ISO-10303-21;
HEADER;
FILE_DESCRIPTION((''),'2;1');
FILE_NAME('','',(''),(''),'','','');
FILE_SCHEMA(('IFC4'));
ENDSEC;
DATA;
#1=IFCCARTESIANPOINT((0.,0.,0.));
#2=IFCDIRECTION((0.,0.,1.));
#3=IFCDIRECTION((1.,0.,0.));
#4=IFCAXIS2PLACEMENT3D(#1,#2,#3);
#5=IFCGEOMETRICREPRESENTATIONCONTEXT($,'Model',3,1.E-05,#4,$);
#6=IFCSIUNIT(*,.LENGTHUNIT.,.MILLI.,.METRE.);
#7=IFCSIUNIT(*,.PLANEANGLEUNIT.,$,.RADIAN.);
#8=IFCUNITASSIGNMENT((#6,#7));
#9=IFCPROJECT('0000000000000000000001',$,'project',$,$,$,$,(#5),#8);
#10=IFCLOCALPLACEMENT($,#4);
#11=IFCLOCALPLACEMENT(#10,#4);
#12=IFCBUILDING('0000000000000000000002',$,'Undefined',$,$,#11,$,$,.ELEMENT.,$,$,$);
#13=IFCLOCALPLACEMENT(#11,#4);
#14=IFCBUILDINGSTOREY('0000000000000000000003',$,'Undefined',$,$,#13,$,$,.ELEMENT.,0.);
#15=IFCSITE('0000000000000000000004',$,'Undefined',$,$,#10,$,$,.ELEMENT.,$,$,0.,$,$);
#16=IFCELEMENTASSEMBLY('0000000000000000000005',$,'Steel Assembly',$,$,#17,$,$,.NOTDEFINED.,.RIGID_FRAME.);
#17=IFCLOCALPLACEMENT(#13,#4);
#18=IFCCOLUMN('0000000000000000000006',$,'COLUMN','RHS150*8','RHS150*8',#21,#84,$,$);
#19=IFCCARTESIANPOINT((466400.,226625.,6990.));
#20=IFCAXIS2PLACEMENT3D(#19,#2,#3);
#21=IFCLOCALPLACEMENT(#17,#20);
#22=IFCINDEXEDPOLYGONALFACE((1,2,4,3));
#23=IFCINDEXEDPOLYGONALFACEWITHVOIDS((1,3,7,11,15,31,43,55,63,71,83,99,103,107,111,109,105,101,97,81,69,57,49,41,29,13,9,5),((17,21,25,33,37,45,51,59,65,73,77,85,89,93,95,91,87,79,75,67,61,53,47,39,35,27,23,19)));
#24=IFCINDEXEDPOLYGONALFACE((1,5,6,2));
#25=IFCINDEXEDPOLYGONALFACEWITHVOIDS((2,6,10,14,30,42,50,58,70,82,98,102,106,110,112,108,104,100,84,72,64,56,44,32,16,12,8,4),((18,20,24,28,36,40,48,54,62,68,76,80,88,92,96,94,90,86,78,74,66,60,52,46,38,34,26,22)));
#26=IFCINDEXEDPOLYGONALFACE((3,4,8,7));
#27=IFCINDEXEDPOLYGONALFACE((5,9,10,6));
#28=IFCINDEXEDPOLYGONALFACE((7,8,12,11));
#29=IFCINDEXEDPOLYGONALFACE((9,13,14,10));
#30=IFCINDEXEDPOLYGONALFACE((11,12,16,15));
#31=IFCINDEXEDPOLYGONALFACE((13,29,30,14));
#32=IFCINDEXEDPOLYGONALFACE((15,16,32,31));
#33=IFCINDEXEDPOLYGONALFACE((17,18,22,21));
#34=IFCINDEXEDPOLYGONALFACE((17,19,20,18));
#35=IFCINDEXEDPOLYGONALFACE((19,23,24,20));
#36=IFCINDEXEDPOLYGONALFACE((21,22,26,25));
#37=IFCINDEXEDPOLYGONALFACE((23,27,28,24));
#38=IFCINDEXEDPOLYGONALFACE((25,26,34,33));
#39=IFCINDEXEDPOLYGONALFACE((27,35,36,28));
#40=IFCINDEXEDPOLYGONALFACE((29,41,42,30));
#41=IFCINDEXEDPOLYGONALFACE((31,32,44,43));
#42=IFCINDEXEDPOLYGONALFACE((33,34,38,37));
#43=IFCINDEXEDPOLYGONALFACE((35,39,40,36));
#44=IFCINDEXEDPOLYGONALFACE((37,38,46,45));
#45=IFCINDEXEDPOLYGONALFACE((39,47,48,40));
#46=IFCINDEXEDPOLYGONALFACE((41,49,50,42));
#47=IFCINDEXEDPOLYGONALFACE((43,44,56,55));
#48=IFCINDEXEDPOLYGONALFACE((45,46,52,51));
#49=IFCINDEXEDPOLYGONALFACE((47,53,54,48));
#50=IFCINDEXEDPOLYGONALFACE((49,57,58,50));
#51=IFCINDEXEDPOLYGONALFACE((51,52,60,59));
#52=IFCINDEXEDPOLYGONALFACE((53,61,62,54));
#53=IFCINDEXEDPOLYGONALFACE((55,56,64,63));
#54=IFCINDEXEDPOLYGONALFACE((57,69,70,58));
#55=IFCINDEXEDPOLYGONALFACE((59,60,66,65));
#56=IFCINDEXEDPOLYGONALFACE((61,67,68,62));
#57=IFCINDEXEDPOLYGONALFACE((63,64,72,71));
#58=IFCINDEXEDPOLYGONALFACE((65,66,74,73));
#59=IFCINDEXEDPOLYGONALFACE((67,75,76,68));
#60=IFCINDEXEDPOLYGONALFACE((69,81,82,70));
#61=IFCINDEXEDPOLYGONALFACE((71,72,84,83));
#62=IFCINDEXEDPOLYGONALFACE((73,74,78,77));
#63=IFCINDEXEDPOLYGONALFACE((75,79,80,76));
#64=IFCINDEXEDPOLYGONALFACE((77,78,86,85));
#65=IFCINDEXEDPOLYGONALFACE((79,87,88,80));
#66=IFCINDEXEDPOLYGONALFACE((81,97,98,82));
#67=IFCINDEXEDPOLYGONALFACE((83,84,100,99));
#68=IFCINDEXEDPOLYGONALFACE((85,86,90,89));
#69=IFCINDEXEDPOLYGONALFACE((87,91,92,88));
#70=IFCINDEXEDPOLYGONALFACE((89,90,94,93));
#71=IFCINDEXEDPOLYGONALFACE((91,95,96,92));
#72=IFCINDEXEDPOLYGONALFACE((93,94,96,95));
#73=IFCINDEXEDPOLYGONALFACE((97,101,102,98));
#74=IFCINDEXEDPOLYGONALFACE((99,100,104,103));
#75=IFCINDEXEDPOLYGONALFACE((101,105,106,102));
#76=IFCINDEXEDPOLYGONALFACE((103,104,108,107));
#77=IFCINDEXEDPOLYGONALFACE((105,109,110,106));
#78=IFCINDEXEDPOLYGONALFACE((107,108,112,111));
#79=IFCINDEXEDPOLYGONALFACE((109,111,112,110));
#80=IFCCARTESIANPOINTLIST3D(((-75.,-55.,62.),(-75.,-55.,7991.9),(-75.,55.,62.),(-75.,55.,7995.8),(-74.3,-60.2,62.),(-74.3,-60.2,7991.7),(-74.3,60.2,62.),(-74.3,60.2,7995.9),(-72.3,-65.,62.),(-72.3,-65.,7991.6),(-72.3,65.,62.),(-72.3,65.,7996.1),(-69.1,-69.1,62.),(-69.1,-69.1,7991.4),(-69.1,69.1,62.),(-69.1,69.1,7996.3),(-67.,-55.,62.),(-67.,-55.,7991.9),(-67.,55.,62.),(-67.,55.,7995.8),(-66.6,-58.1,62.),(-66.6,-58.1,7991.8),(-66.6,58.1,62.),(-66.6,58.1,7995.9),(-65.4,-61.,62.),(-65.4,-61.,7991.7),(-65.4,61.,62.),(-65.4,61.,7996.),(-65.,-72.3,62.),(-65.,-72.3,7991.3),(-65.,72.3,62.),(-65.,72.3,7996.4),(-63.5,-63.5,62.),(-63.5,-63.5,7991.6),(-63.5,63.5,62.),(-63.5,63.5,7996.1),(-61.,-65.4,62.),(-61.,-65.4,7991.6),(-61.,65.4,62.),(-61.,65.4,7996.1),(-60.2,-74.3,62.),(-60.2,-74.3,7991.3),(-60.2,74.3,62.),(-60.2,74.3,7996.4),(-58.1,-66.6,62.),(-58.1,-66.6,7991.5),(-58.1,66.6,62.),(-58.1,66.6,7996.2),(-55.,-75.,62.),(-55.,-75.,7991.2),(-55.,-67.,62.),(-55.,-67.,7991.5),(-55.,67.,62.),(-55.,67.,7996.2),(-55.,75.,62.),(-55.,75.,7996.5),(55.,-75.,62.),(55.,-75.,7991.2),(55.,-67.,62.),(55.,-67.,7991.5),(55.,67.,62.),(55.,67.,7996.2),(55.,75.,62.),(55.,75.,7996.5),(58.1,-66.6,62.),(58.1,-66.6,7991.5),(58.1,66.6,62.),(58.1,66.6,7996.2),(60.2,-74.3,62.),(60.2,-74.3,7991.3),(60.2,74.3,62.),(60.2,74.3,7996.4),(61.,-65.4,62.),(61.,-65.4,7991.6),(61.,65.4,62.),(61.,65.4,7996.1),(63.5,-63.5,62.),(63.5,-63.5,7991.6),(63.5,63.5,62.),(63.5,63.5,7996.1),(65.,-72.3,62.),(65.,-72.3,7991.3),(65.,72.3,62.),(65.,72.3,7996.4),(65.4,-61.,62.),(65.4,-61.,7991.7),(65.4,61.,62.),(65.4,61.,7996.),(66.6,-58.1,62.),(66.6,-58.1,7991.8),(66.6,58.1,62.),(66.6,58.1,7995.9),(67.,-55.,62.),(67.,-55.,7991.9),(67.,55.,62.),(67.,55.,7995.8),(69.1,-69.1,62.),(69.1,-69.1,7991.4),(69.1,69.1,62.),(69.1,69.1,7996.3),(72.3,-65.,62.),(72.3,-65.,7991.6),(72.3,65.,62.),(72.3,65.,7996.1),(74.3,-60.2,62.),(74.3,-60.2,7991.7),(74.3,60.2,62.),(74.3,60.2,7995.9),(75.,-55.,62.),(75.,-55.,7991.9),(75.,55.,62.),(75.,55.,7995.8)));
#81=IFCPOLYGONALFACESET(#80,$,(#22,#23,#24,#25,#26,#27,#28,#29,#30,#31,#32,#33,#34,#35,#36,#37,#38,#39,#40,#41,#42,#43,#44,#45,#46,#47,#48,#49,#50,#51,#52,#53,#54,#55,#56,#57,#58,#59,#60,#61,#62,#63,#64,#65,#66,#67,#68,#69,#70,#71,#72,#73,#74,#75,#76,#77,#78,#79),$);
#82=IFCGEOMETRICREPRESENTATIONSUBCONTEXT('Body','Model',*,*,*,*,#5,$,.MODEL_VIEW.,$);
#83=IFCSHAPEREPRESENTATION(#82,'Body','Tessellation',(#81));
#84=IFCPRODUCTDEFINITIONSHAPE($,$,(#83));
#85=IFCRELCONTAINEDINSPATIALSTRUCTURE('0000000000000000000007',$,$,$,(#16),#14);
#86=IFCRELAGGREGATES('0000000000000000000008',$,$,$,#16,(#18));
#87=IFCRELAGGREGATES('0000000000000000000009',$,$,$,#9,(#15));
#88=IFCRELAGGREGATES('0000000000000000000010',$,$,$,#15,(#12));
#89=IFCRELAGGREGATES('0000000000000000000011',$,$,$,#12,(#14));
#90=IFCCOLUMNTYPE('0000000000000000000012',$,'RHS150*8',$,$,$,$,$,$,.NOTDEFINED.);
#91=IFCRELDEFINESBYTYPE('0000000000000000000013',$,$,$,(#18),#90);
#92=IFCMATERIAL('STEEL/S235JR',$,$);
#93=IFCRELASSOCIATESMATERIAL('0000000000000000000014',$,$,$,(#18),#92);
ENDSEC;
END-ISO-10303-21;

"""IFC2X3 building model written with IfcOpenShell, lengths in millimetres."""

from ifc_helpers import new_model, si_unit, frame, origin_with_axes, origin_2d_with_axis, place, context, subcontext, project, spatial, hollow_rectangle, extrude, clip, halfspace, material, type_object, element, aggregate, save


model = new_model("IFC2X3")

# Units and contexts
model_context = context("Model", 3, precision=1e-05, world=origin_with_axes())
body_context = subcontext(model_context, "Body", "Model", "MODEL_VIEW")
ifc_project = project(units=[si_unit("LENGTHUNIT", "METRE", prefix="MILLI"), si_unit("PLANEANGLEUNIT", "RADIAN")], contexts=[model_context])

# Site, building, storey
site_placement = place(None, origin_with_axes())
site = spatial("IfcSite", under=ifc_project, at=site_placement, Name="Undefined", CompositionType="ELEMENT", RefElevation=0.0)
building_placement = place(site_placement, origin_with_axes())
building = spatial("IfcBuilding", under=site, at=building_placement, Name="Undefined", CompositionType="ELEMENT")
storey_placement = place(building_placement, origin_with_axes())
storey = spatial("IfcBuildingStorey", under=building, at=storey_placement, Name="Undefined", CompositionType="ELEMENT", Elevation=0.0)

# Element assembly, column
ifc_material_1 = material(Name="STEEL/S235JR")
assembly_1_placement = place(storey_placement, origin_with_axes())
assembly_1 = element("IfcElementAssembly", 1, at=assembly_1_placement, inside=storey, Name="Steel Assembly", AssemblyPlace="NOTDEFINED", PredefinedType="RIGID_FRAME")
column_type_1 = type_object("IfcColumnType", Name="RHS150*8", PredefinedType="NOTDEFINED")
column_1_placement = place(assembly_1_placement, frame((466400.0, 226625.0, 6990.0), z_axis=(0.0, 0.0, 1.0), x_axis=(1.0, 0.0, 0.0)))
column_1 = element("IfcColumn", 2, at=column_1_placement, type_object=column_type_1, material=ifc_material_1, Name="COLUMN", Description="RHS150*8", ObjectType="RHS150*8", context=body_context, shape_type="Clipping", body=[
    clip(extrude(hollow_rectangle(XDim=150.0, YDim=150.0, WallThickness=8.0, InnerFilletRadius=12.0, OuterFilletRadius=20.0, at=origin_2d_with_axis()), frame((0.0, 0.0, 7996.5), z_axis=(0.0, 0.0, -1.0), x_axis=(-1.0, 0.0, 0.0)), (0.0, 0.0, 1.0), 7934.5), halfspace(frame((0.0, -89.2, 7990.7), z_axis=(0.0, 0.034899, -0.999391), x_axis=(1.0, 0.0, 0.0)), True)),
])

aggregate(assembly_1, [column_1])

save(model, "model.ifc")
